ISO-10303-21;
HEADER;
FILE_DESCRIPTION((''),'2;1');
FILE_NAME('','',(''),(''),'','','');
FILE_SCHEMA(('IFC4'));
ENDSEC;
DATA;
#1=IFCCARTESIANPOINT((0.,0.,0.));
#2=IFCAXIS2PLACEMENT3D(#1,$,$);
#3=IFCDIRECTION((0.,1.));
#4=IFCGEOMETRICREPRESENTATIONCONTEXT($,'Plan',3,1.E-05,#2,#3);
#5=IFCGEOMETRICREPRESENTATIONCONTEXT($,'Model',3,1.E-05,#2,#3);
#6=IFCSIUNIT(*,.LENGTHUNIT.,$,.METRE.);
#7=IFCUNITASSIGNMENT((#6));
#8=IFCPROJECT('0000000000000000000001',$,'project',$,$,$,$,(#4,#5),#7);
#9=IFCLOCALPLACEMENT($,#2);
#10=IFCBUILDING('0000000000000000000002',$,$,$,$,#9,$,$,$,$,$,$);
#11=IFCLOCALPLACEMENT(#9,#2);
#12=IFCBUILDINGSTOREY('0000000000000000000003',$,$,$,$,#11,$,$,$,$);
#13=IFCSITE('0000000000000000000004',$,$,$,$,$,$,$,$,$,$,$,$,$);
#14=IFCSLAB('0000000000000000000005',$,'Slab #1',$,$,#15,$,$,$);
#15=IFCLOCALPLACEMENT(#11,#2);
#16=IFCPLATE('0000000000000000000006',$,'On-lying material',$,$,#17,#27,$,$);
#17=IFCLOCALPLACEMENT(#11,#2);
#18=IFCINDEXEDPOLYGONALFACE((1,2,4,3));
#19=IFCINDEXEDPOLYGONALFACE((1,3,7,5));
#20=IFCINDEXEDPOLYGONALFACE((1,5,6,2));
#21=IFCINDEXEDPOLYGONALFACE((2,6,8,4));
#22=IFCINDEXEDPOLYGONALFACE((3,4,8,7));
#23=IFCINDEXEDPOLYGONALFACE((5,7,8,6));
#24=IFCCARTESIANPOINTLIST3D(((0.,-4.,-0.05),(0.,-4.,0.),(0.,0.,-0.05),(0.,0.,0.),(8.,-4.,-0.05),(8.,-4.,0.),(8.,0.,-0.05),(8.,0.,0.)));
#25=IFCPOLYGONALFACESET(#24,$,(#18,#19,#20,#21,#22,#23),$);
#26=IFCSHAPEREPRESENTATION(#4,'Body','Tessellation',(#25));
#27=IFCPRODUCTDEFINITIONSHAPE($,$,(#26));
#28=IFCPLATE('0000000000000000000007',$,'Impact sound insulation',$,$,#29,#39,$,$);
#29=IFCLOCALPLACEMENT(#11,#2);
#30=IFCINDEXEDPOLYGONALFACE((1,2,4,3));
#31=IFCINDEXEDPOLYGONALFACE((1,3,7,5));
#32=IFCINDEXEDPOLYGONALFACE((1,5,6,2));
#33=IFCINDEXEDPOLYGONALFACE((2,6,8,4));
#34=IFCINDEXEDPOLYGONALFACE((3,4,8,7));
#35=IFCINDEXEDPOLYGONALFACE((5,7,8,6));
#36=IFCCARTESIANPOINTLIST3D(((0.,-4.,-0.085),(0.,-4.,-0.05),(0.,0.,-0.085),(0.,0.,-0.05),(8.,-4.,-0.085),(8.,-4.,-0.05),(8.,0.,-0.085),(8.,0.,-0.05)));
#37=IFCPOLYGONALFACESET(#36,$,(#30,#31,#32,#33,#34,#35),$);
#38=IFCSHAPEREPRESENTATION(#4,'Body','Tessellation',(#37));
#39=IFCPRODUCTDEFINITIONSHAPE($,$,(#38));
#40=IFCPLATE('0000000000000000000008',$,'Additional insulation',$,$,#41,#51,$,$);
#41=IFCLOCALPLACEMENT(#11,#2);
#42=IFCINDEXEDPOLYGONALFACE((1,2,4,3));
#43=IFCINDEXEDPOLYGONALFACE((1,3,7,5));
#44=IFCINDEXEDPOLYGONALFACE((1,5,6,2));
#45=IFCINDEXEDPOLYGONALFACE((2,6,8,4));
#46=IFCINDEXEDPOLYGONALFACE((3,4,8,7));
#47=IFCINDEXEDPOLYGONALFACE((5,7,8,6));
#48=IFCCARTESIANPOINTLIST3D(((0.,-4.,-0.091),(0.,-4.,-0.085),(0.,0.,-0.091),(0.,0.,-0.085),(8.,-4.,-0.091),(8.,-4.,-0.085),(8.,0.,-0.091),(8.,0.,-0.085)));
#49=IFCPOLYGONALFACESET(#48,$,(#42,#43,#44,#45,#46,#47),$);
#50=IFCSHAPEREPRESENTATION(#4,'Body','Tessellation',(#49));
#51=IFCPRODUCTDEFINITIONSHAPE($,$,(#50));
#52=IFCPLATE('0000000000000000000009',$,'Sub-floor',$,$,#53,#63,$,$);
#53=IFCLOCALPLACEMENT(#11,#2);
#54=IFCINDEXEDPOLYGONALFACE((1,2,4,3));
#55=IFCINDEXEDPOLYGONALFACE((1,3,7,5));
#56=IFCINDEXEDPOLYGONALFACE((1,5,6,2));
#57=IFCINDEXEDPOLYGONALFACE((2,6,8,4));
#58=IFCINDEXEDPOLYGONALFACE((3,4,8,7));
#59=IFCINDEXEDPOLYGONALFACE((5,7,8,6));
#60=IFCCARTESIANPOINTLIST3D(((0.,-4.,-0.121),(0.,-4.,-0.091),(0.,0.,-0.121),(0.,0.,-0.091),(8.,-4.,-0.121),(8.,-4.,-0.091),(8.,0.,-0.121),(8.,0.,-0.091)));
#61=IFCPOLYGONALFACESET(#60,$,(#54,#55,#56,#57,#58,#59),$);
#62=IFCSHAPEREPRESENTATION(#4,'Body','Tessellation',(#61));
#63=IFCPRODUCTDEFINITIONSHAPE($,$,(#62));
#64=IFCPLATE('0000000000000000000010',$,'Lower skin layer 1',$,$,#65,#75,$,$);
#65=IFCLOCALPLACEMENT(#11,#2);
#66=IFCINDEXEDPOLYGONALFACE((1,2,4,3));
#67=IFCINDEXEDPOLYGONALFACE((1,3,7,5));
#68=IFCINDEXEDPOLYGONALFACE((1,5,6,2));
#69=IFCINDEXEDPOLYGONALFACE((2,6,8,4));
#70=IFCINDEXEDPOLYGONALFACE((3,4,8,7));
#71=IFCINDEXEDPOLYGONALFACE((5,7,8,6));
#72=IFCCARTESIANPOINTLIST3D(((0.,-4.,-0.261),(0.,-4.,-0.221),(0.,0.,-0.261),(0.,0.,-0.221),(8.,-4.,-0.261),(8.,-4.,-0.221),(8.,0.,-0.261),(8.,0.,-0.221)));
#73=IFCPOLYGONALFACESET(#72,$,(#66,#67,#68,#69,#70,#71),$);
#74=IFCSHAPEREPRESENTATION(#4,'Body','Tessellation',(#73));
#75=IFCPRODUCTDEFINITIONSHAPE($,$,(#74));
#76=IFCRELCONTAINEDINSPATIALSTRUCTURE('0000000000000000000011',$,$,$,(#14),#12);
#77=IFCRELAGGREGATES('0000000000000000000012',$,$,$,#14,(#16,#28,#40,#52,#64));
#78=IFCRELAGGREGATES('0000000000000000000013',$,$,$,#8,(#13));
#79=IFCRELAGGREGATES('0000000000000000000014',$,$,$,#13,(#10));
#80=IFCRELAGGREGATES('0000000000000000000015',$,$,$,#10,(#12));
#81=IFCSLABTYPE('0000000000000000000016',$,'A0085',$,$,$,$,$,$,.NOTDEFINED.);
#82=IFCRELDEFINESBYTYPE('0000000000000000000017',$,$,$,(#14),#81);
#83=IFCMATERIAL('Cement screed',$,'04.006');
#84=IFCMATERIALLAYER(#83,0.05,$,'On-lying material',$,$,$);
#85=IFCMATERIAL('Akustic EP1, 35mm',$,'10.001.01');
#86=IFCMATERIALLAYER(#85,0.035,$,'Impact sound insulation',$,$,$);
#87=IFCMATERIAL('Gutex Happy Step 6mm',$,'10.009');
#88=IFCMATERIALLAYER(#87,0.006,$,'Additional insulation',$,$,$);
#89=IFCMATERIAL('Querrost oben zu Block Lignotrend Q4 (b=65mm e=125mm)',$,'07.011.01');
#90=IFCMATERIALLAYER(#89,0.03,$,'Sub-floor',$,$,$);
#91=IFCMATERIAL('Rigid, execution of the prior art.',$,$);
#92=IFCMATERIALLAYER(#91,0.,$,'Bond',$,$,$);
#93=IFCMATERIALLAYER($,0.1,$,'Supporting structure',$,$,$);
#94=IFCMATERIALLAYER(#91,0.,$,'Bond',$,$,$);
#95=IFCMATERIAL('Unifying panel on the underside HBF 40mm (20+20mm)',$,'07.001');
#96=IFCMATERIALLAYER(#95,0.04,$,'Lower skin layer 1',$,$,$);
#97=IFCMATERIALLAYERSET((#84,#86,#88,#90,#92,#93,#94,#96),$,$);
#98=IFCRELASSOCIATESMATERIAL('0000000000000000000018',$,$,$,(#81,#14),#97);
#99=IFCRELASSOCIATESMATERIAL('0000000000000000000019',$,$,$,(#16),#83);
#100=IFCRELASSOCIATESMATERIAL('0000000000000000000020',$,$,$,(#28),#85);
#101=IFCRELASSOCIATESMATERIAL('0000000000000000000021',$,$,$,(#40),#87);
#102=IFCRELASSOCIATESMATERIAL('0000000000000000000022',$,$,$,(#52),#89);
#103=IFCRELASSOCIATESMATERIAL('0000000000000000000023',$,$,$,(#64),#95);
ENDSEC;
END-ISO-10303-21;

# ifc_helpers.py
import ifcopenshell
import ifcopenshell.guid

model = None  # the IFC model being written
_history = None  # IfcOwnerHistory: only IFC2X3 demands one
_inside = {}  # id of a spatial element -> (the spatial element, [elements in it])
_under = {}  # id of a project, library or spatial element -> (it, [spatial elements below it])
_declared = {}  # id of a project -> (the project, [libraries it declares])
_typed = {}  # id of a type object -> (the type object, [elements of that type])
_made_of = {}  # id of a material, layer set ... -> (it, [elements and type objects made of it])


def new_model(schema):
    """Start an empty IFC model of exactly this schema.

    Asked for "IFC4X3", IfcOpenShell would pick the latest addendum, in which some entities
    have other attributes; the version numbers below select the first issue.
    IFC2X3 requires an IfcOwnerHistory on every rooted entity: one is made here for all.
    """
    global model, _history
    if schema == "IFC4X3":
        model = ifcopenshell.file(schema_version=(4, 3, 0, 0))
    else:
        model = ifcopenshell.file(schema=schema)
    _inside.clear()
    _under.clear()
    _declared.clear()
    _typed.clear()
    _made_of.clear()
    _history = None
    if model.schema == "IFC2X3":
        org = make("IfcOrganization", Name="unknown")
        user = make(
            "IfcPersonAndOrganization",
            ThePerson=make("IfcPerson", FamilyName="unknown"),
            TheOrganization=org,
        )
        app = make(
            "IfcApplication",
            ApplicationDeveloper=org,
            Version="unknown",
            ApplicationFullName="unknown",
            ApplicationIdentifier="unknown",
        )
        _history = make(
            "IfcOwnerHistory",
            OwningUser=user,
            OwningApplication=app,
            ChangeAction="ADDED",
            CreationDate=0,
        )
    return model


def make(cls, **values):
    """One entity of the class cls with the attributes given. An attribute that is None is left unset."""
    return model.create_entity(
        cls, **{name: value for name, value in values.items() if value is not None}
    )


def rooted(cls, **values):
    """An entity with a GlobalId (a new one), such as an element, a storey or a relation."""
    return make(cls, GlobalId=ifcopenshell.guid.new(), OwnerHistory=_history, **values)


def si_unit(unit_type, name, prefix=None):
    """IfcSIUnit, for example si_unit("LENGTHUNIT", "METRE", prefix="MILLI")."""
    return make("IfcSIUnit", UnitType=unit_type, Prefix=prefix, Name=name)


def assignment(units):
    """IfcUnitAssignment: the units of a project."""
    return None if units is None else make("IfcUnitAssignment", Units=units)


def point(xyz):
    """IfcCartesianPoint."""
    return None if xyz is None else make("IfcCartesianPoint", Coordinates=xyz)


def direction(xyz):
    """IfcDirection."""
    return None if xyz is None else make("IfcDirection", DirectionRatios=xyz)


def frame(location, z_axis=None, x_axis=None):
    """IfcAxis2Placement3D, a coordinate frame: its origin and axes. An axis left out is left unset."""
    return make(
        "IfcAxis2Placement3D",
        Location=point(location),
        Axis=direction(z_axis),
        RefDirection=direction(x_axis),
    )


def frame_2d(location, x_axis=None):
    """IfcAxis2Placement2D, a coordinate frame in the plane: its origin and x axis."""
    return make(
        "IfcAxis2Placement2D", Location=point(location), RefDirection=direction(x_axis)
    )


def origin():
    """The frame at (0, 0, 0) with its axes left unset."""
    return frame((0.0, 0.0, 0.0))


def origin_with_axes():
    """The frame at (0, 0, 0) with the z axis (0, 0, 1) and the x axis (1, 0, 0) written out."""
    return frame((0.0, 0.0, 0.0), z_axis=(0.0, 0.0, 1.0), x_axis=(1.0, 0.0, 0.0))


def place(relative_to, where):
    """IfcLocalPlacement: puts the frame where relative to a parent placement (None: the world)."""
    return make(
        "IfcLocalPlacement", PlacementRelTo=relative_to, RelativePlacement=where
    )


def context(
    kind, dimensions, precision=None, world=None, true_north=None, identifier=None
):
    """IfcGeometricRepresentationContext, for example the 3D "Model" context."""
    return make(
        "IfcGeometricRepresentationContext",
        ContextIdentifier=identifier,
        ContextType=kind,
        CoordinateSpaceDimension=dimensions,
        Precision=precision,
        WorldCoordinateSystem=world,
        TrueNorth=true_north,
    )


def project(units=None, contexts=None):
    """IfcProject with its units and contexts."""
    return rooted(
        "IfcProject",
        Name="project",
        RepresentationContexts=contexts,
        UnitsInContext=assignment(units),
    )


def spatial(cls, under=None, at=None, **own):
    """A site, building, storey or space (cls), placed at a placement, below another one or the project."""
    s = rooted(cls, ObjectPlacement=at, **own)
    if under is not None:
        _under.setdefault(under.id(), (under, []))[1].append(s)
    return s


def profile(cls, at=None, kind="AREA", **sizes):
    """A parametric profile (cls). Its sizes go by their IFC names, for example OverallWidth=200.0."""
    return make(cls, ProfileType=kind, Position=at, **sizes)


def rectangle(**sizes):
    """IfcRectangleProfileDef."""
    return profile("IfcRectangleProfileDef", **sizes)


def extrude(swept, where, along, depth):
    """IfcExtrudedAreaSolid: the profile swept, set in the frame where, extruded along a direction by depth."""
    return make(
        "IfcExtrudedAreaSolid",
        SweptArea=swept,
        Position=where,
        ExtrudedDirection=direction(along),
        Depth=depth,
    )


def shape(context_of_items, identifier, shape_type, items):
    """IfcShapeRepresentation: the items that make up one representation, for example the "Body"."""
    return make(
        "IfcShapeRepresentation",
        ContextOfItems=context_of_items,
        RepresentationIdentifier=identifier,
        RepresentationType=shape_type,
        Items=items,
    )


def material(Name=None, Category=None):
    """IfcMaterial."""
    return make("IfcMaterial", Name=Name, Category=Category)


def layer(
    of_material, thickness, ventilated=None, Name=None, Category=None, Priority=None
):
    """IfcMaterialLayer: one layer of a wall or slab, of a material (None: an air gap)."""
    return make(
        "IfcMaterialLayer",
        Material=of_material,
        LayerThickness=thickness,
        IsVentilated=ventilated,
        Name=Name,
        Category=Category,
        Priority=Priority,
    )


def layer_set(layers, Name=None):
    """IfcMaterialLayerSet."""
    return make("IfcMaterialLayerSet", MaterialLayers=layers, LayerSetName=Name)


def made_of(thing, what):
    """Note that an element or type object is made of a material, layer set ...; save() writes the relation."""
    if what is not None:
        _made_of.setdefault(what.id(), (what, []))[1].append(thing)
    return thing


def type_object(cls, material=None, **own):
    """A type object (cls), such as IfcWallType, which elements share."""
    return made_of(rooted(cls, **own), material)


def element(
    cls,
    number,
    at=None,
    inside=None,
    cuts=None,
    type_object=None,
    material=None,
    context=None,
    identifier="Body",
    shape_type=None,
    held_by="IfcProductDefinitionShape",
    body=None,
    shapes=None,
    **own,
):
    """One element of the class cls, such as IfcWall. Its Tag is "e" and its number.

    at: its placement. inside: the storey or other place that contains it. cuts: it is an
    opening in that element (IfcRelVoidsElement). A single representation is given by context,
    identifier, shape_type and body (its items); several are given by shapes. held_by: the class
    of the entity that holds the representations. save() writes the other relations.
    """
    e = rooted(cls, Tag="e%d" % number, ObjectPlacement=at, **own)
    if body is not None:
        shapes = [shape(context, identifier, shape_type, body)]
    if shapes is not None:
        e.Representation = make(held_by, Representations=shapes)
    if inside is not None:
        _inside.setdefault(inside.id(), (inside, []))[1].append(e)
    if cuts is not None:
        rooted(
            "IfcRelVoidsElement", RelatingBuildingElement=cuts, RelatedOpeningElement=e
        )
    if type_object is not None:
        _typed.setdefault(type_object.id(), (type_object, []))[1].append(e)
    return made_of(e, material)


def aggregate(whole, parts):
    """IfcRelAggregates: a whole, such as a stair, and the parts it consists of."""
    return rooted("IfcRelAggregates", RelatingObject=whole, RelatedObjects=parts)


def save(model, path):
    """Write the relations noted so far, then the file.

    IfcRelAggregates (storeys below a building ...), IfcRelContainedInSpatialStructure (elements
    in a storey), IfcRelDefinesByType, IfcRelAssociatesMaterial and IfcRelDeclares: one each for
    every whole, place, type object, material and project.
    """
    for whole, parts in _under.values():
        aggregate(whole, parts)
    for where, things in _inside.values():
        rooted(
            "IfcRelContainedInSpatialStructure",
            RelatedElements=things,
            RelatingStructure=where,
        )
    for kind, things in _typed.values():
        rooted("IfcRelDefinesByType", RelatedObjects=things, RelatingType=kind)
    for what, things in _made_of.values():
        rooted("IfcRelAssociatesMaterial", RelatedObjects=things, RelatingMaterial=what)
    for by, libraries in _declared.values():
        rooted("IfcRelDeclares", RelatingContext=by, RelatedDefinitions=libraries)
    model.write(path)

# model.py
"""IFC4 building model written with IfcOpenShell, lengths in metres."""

from ifc_helpers import new_model, si_unit, direction, frame, frame_2d, origin, origin_with_axes, place, context, project, spatial, rectangle, extrude, material, layer, layer_set, type_object, element, aggregate, save


model = new_model("IFC4")

# Units and contexts
plan_context = context("Plan", 3, precision=1e-05, world=origin(), true_north=direction((0.0, 1.0)))
model_context = context("Model", 3, precision=1e-05, world=origin(), true_north=direction((0.0, 1.0)))
ifc_project = project(units=[si_unit("LENGTHUNIT", "METRE")], contexts=[plan_context, model_context])

# Site, building, storey
site = spatial("IfcSite", under=ifc_project)
building_placement = place(None, origin())
building = spatial("IfcBuilding", under=site, at=building_placement)
storey_placement = place(building_placement, origin())
storey = spatial("IfcBuildingStorey", under=building, at=storey_placement)

# Slab, plates
ifc_material_1 = material(Name="Cement screed", Category="04.006")
ifc_layer_1 = layer(ifc_material_1, 0.05, Name="On-lying material")
ifc_material_2 = material(Name="Akustic EP1, 35mm", Category="10.001.01")
ifc_layer_2 = layer(ifc_material_2, 0.035, Name="Impact sound insulation")
ifc_material_3 = material(Name="Gutex Happy Step 6mm", Category="10.009")
ifc_layer_3 = layer(ifc_material_3, 0.006, Name="Additional insulation")
ifc_material_4 = material(Name="Querrost oben zu Block Lignotrend Q4 (b=65mm e=125mm)", Category="07.011.01")
ifc_layer_4 = layer(ifc_material_4, 0.03, Name="Sub-floor")
ifc_material_5 = material(Name="Rigid, execution of the prior art.")
ifc_layer_5 = layer(ifc_material_5, 0.0, Name="Bond")
ifc_layer_6 = layer(None, 0.1, Name="Supporting structure")
ifc_layer_7 = layer(ifc_material_5, 0.0, Name="Bond")
ifc_material_6 = material(Name="Unifying panel on the underside HBF 40mm (20+20mm)", Category="07.001")
ifc_layer_8 = layer(ifc_material_6, 0.04, Name="Lower skin layer 1")
ifc_layer_set = layer_set([ifc_layer_1, ifc_layer_2, ifc_layer_3, ifc_layer_4, ifc_layer_5, ifc_layer_6, ifc_layer_7, ifc_layer_8])
slab_type = type_object("IfcSlabType", Name="A0085", PredefinedType="NOTDEFINED", material=ifc_layer_set)
slab_placement = place(None, frame((0.0, 0.0, 0.0), z_axis=(0.0, 0.0, -1.0), x_axis=(1.0, 0.0, 0.0)))
slab = element("IfcSlab", 1, at=slab_placement, inside=storey, type_object=slab_type, material=ifc_layer_set, Name="Slab #1")
plate_1_placement = place(slab_placement, origin())
plate_1 = element("IfcPlate", 2, at=plate_1_placement, material=ifc_material_1, Name="On-lying material", context=plan_context, shape_type="SweptSolid", body=[
    extrude(rectangle(XDim=8.0, YDim=4.0, at=frame_2d((4.0, 2.0), x_axis=(1.0, 0.0))), origin_with_axes(), (0.0, 0.0, 1.0), 0.05),
])
plate_2_placement = place(slab_placement, origin())
plate_2 = element("IfcPlate", 3, at=plate_2_placement, material=ifc_material_2, Name="Impact sound insulation", context=plan_context, shape_type="SweptSolid", body=[
    extrude(rectangle(XDim=8.0, YDim=4.0, at=frame_2d((4.0, 2.0), x_axis=(1.0, 0.0))), frame((0.0, 0.0, 0.05), z_axis=(0.0, 0.0, 1.0), x_axis=(1.0, 0.0, 0.0)), (0.0, 0.0, 1.0), 0.035),
])
plate_3_placement = place(slab_placement, origin())
plate_3 = element("IfcPlate", 4, at=plate_3_placement, material=ifc_material_3, Name="Additional insulation", context=plan_context, shape_type="SweptSolid", body=[
    extrude(rectangle(XDim=8.0, YDim=4.0, at=frame_2d((4.0, 2.0), x_axis=(1.0, 0.0))), frame((0.0, 0.0, 0.085), z_axis=(0.0, 0.0, 1.0), x_axis=(1.0, 0.0, 0.0)), (0.0, 0.0, 1.0), 0.006),
])
plate_4_placement = place(slab_placement, origin())
plate_4 = element("IfcPlate", 5, at=plate_4_placement, material=ifc_material_4, Name="Sub-floor", context=plan_context, shape_type="SweptSolid", body=[
    extrude(rectangle(XDim=8.0, YDim=4.0, at=frame_2d((4.0, 2.0), x_axis=(1.0, 0.0))), frame((0.0, 0.0, 0.091), z_axis=(0.0, 0.0, 1.0), x_axis=(1.0, 0.0, 0.0)), (0.0, 0.0, 1.0), 0.03),
])
plate_5_placement = place(slab_placement, origin())
plate_5 = element("IfcPlate", 6, at=plate_5_placement, material=ifc_material_6, Name="Lower skin layer 1", context=plan_context, shape_type="SweptSolid", body=[
    extrude(rectangle(XDim=8.0, YDim=4.0, at=frame_2d((4.0, 2.0), x_axis=(1.0, 0.0))), frame((0.0, 0.0, 0.221), z_axis=(0.0, 0.0, 1.0), x_axis=(1.0, 0.0, 0.0)), (0.0, 0.0, 1.0), 0.04),
])
aggregate(slab, [plate_1, plate_2, plate_3, plate_4, plate_5])

save(model, "model.ifc")
